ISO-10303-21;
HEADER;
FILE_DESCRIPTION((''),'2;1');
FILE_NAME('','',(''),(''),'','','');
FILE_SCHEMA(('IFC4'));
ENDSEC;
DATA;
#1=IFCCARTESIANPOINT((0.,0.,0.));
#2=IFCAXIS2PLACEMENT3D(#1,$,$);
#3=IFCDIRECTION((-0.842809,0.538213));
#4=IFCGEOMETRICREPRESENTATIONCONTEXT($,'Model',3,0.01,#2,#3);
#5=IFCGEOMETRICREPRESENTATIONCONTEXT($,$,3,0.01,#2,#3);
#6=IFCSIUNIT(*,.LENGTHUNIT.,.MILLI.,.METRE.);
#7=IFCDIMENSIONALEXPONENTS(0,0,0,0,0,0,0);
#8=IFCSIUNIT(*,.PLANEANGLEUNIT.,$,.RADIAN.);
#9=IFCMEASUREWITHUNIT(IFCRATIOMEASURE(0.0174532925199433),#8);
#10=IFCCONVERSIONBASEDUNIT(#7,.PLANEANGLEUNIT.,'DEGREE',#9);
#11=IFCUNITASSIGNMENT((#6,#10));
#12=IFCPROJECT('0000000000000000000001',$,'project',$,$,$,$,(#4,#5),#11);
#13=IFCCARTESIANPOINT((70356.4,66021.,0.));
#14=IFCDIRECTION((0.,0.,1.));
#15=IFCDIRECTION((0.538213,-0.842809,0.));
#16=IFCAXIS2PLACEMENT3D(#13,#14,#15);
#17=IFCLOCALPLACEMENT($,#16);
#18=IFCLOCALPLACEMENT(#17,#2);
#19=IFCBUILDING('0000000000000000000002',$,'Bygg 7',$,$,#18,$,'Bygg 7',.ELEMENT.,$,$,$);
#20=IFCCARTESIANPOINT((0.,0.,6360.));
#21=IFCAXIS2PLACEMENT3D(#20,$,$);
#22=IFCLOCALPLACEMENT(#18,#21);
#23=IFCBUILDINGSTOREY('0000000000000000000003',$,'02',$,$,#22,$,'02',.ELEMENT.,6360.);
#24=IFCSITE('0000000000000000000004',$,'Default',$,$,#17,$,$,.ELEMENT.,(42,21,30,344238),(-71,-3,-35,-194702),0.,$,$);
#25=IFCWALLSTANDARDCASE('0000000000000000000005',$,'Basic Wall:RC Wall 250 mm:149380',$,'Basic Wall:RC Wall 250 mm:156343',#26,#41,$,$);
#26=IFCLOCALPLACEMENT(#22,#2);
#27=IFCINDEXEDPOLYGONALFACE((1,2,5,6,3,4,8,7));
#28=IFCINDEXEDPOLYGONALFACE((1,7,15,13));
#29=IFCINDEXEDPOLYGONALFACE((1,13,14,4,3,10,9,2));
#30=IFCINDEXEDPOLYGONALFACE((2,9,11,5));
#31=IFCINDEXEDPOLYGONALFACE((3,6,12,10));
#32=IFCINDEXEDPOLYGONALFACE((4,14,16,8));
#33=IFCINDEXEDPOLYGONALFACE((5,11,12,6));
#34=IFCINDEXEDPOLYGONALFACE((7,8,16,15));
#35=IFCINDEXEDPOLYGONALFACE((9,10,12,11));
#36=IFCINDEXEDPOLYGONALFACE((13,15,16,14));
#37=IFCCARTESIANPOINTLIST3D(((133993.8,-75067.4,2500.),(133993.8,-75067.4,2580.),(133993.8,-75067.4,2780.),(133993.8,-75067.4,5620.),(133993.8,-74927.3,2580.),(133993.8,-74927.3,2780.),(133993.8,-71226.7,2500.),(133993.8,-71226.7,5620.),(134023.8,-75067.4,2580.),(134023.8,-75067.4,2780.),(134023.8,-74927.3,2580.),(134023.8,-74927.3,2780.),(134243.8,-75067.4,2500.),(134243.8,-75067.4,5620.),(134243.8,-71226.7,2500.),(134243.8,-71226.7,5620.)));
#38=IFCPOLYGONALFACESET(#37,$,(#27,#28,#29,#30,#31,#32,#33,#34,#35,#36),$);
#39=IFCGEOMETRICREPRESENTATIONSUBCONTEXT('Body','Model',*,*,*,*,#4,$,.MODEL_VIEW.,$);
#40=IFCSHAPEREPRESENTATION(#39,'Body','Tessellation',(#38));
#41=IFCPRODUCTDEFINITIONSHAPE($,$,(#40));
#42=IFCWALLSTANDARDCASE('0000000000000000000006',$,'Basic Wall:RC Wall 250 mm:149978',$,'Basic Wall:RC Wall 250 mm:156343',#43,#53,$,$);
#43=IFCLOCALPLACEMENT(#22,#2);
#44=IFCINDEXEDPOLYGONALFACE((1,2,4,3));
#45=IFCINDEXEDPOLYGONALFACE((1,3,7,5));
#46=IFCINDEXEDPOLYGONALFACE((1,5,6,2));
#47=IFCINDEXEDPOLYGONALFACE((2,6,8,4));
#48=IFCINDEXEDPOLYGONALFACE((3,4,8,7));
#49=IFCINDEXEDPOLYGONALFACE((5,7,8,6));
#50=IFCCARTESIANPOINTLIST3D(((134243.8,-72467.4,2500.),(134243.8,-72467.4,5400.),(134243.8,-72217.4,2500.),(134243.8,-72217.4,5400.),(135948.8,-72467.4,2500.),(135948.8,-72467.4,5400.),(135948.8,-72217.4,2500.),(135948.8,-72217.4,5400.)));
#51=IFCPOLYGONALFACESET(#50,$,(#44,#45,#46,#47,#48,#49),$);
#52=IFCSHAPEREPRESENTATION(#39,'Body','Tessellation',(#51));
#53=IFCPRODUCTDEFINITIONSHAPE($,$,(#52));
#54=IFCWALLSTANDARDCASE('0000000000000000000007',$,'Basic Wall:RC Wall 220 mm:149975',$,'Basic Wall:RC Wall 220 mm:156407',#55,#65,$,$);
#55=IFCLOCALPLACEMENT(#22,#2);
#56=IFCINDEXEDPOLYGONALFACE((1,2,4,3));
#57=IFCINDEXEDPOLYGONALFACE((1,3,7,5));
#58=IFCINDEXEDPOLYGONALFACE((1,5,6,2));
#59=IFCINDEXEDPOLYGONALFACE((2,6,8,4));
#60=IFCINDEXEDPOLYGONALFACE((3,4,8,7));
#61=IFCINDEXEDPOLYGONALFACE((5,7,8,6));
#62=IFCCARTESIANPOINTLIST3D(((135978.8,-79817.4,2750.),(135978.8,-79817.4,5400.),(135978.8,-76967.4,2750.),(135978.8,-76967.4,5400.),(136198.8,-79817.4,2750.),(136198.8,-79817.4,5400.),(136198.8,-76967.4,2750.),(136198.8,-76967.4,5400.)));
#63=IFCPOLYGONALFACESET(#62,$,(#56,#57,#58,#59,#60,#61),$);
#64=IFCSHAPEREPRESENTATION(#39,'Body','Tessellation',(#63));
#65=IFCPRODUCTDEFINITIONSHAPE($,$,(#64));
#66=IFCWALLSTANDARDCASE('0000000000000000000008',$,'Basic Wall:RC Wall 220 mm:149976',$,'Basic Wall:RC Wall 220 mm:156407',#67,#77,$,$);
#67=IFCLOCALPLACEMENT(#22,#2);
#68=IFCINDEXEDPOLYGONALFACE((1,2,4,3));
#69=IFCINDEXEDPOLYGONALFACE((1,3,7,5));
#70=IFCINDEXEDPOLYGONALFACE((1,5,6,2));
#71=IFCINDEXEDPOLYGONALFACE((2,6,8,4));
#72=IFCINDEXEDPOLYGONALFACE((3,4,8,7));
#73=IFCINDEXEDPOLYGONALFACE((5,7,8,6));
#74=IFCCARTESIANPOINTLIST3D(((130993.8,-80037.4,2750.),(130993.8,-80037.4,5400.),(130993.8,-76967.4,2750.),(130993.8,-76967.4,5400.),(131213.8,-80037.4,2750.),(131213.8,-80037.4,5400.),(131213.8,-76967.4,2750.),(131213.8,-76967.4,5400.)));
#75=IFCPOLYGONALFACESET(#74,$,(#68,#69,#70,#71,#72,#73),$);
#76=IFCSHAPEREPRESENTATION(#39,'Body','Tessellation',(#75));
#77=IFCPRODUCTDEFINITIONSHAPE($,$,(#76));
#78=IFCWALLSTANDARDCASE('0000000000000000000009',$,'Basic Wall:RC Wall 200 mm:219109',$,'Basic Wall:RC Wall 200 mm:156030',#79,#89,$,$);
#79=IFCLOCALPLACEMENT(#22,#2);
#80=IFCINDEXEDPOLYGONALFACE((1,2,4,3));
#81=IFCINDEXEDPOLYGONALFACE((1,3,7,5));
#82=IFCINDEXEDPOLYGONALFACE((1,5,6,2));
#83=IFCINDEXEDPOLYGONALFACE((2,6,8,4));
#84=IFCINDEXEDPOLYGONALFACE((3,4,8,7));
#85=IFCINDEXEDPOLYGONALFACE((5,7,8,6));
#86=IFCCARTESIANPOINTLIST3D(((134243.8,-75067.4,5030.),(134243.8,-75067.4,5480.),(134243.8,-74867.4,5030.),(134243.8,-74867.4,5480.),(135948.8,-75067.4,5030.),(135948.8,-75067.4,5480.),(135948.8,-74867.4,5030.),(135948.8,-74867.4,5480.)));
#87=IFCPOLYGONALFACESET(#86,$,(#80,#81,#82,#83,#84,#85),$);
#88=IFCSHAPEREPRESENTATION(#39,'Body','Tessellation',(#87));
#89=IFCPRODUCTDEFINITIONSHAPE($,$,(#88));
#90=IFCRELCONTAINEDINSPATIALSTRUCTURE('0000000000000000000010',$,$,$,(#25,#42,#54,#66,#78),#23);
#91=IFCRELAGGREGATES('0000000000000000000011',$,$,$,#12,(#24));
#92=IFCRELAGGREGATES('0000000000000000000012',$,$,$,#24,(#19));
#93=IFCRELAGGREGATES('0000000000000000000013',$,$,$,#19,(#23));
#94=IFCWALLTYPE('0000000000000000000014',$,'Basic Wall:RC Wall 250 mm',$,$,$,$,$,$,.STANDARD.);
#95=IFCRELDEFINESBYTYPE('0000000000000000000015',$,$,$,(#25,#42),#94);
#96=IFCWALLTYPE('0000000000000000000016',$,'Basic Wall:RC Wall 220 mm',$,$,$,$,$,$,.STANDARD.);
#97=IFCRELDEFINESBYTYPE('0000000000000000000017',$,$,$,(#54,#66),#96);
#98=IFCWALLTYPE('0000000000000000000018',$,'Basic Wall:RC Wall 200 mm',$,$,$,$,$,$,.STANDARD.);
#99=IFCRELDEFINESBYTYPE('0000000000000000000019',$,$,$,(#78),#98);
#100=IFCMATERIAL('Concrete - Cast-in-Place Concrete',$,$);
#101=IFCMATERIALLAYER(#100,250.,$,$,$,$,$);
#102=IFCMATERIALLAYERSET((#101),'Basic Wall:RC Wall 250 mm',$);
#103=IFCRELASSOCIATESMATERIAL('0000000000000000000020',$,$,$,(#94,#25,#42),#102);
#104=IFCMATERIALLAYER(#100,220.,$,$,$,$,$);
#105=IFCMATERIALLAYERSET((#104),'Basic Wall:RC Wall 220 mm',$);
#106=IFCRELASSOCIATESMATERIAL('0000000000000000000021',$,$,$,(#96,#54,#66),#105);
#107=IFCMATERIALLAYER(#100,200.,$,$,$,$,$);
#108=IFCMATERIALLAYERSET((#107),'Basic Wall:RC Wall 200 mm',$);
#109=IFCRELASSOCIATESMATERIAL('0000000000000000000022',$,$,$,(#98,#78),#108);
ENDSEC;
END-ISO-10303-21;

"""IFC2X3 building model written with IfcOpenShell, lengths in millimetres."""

from ifc_helpers import new_model, entity, si_unit, converted_unit, direction, frame, frame_2d, origin, place, context, subcontext, project, spatial, polyline, rectangle, extrude, clip, bounded_halfspace, material, layer, layer_set, layer_usage, type_object, element, save


model = new_model("IFC2X3")

# Units and contexts
model_context = context("Model", 3, precision=0.01, world=origin(), true_north=direction((-0.842809, 0.538213)))
context_of_model = context(None, 3, precision=0.01, world=origin(), true_north=direction((-0.842809, 0.538213)))
body_context = subcontext(model_context, "Body", "Model", "MODEL_VIEW")
ifc_project = project(units=[si_unit("LENGTHUNIT", "METRE", prefix="MILLI"), converted_unit("PLANEANGLEUNIT", "DEGREE", entity("IfcRatioMeasure", 0.0174532925199433), si_unit("PLANEANGLEUNIT", "RADIAN"), dimensions=[0, 0, 0, 0, 0, 0, 0])], contexts=[model_context, context_of_model])

# Site, building, storey
site_placement = place(None, frame((70356.4, 66021.0, 0.0), z_axis=(0.0, 0.0, 1.0), x_axis=(0.538213, -0.842809, 0.0)))
site = spatial("IfcSite", under=ifc_project, at=site_placement, Name="Default", CompositionType="ELEMENT", RefLatitude=(42, 21, 30, 344238), RefLongitude=(-71, -3, -35, -194702), RefElevation=0.0)
building_placement = place(site_placement, origin())
building = spatial("IfcBuilding", under=site, at=building_placement, Name="Bygg 7", LongName="Bygg 7", CompositionType="ELEMENT")
storey_placement = place(building_placement, frame((0.0, 0.0, 6360.0)))
storey = spatial("IfcBuildingStorey", under=building, at=storey_placement, Name="02", LongName="02", CompositionType="ELEMENT", Elevation=6360.0)

# Shared definitions
ifc_material_1 = material(Name="Concrete - Cast-in-Place Concrete")

# Wall, opening
ifc_layer_1 = layer(ifc_material_1, 250.0)
ifc_layer_set_1 = layer_set([ifc_layer_1], Name="Basic Wall:RC Wall 250 mm")
wall_type_1 = type_object("IfcWallType", Name="Basic Wall:RC Wall 250 mm", PredefinedType="STANDARD", material=ifc_layer_set_1)
ifc_layer_usage_1 = layer_usage(ifc_layer_set_1, "AXIS2", "NEGATIVE", 125.0)
wall_1_placement = place(storey_placement, frame((134118.8, -75067.4, 2500.0), z_axis=(0.0, 0.0, 1.0), x_axis=(0.0, 1.0, 0.0)))
wall_1 = element("IfcWallStandardCase", 1, at=wall_1_placement, inside=storey, type_object=wall_type_1, material=ifc_layer_usage_1, Name="Basic Wall:RC Wall 250 mm:149380", ObjectType="Basic Wall:RC Wall 250 mm:156343", context=body_context, shape_type="SweptSolid", body=[
    extrude(rectangle(XDim=3840.6, YDim=250.0, at=frame_2d((1920.3, 0.0), x_axis=(-1.0, 0.0))), origin(), (0.0, 0.0, 1.0), 3120.0),
])
opening_1_placement = place(storey_placement, frame((134118.8, -75067.4, 2500.0), z_axis=(0.0, 0.0, 1.0), x_axis=(0.0, 1.0, 0.0)))
element("IfcOpeningElement", 2, at=opening_1_placement, cuts=wall_1, ObjectType="Opening", context=body_context, shape_type="SweptSolid", body=[
    extrude(rectangle(XDim=140.0, YDim=30.0, at=frame_2d((0.0, 0.0), x_axis=(1.0, 0.0))), frame((70.0, 110.0, 80.0)), (0.0, 0.0, 1.0), 200.0),
])

# Wall
ifc_layer_usage_2 = layer_usage(ifc_layer_set_1, "AXIS2", "NEGATIVE", 125.0)
wall_2_placement = place(storey_placement, frame((134243.8, -72342.4, 2500.0)))
element("IfcWallStandardCase", 3, at=wall_2_placement, inside=storey, type_object=wall_type_1, material=ifc_layer_usage_2, Name="Basic Wall:RC Wall 250 mm:149978", ObjectType="Basic Wall:RC Wall 250 mm:156343", context=body_context, shape_type="SweptSolid", body=[
    extrude(rectangle(XDim=1705.0, YDim=250.0, at=frame_2d((852.5, 0.0), x_axis=(-1.0, 0.0))), origin(), (0.0, 0.0, 1.0), 2900.0),
])

# Shared definitions
ifc_layer_2 = layer(ifc_material_1, 220.0)
ifc_layer_set_2 = layer_set([ifc_layer_2], Name="Basic Wall:RC Wall 220 mm")
wall_type_2 = type_object("IfcWallType", Name="Basic Wall:RC Wall 220 mm", PredefinedType="STANDARD", material=ifc_layer_set_2)

# Walls
ifc_layer_usage_3 = layer_usage(ifc_layer_set_2, "AXIS2", "NEGATIVE", 110.0)
wall_3_placement = place(storey_placement, frame((136088.8, -79817.4, 2750.0), z_axis=(0.0, 0.0, 1.0), x_axis=(0.0, 1.0, 0.0)))
element("IfcWallStandardCase", 4, at=wall_3_placement, inside=storey, type_object=wall_type_2, material=ifc_layer_usage_3, Name="Basic Wall:RC Wall 220 mm:149975", ObjectType="Basic Wall:RC Wall 220 mm:156407", context=body_context, shape_type="Clipping", body=[
    clip(clip(extrude(rectangle(XDim=2850.0, YDim=220.0, at=frame_2d((1425.0, 0.0), x_axis=(-1.0, 0.0))), origin(), (0.0, 0.0, 1.0), 2650.0), bounded_halfspace(frame((0.0, -110.0, 2650.0), z_axis=(0.0, 0.0, -1.0), x_axis=(-0.99571, -0.092529, 0.0)), True, frame((0.0, -110.0, 2650.0)), polyline([(0.0, 0.0), (2850.0, 0.0), (2850.0, 220.0), (454.0, 220.0), (0.0, 220.0), (0.0, 0.0)]))), bounded_halfspace(frame((2850.0, -110.0, 0.0), z_axis=(0.0, 0.0, 1.0), x_axis=(0.0, 1.0, 0.0)), True, frame((2850.0, -110.0, 0.0)), polyline([(0.0, 0.0), (0.0, 220.0), (-2396.0, 220.0), (-2850.0, 220.0), (-2850.0, 0.0), (0.0, 0.0)]))),
])
ifc_layer_usage_4 = layer_usage(ifc_layer_set_2, "AXIS2", "NEGATIVE", 110.0)
wall_4_placement = place(storey_placement, frame((131103.8, -80037.4, 2750.0), z_axis=(0.0, 0.0, 1.0), x_axis=(0.0, 1.0, 0.0)))
element("IfcWallStandardCase", 5, at=wall_4_placement, inside=storey, type_object=wall_type_2, material=ifc_layer_usage_4, Name="Basic Wall:RC Wall 220 mm:149976", ObjectType="Basic Wall:RC Wall 220 mm:156407", context=body_context, shape_type="Clipping", body=[
    clip(clip(extrude(rectangle(XDim=3070.0, YDim=220.0, at=frame_2d((1535.0, 0.0), x_axis=(-1.0, 0.0))), origin(), (0.0, 0.0, 1.0), 2650.0), bounded_halfspace(frame((3070.0, -110.0, 0.0), z_axis=(0.0, 0.0, 1.0), x_axis=(0.0, 1.0, 0.0)), True, frame((3070.0, -110.0, 0.0)), polyline([(0.0, 0.0), (0.0, 220.0), (-2850.0, 220.0), (-3070.0, 220.0), (-3070.0, 0.0), (0.0, 0.0)]))), bounded_halfspace(frame((0.0, -110.0, 2650.0), z_axis=(0.0, 0.0, -1.0), x_axis=(-0.99571, -0.092529, 0.0)), True, frame((0.0, -110.0, 2650.0)), polyline([(0.0, 0.0), (3070.0, 0.0), (3070.0, 220.0), (220.0, 220.0), (0.0, 220.0), (0.0, 0.0)]))),
])
ifc_layer_3 = layer(ifc_material_1, 200.0)
ifc_layer_set_3 = layer_set([ifc_layer_3], Name="Basic Wall:RC Wall 200 mm")
ifc_layer_usage_5 = layer_usage(ifc_layer_set_3, "AXIS2", "NEGATIVE", 100.0)
wall_type_3 = type_object("IfcWallType", Name="Basic Wall:RC Wall 200 mm", PredefinedType="STANDARD", material=ifc_layer_set_3)
wall_5_placement = place(storey_placement, frame((134243.8, -74967.4, 5030.0)))
element("IfcWallStandardCase", 6, at=wall_5_placement, inside=storey, type_object=wall_type_3, material=ifc_layer_usage_5, Name="Basic Wall:RC Wall 200 mm:219109", ObjectType="Basic Wall:RC Wall 200 mm:156030", context=body_context, shape_type="Clipping", body=[
    clip(extrude(rectangle(XDim=1705.0, YDim=200.0, at=frame_2d((852.5, 0.0), x_axis=(-1.0, 0.0))), origin(), (0.0, 0.0, 1.0), 450.0), bounded_halfspace(frame((0.0, -100.0, 450.0), z_axis=(0.0, 0.0, -1.0), x_axis=(1.0, 0.0, 0.0)), True, frame((0.0, -100.0, 450.0)), polyline([(0.0, 0.0), (1705.0, 0.0), (1705.0, 200.0), (0.0, 200.0), (0.0, 0.0)]))),
])

save(model, "model.ifc")
